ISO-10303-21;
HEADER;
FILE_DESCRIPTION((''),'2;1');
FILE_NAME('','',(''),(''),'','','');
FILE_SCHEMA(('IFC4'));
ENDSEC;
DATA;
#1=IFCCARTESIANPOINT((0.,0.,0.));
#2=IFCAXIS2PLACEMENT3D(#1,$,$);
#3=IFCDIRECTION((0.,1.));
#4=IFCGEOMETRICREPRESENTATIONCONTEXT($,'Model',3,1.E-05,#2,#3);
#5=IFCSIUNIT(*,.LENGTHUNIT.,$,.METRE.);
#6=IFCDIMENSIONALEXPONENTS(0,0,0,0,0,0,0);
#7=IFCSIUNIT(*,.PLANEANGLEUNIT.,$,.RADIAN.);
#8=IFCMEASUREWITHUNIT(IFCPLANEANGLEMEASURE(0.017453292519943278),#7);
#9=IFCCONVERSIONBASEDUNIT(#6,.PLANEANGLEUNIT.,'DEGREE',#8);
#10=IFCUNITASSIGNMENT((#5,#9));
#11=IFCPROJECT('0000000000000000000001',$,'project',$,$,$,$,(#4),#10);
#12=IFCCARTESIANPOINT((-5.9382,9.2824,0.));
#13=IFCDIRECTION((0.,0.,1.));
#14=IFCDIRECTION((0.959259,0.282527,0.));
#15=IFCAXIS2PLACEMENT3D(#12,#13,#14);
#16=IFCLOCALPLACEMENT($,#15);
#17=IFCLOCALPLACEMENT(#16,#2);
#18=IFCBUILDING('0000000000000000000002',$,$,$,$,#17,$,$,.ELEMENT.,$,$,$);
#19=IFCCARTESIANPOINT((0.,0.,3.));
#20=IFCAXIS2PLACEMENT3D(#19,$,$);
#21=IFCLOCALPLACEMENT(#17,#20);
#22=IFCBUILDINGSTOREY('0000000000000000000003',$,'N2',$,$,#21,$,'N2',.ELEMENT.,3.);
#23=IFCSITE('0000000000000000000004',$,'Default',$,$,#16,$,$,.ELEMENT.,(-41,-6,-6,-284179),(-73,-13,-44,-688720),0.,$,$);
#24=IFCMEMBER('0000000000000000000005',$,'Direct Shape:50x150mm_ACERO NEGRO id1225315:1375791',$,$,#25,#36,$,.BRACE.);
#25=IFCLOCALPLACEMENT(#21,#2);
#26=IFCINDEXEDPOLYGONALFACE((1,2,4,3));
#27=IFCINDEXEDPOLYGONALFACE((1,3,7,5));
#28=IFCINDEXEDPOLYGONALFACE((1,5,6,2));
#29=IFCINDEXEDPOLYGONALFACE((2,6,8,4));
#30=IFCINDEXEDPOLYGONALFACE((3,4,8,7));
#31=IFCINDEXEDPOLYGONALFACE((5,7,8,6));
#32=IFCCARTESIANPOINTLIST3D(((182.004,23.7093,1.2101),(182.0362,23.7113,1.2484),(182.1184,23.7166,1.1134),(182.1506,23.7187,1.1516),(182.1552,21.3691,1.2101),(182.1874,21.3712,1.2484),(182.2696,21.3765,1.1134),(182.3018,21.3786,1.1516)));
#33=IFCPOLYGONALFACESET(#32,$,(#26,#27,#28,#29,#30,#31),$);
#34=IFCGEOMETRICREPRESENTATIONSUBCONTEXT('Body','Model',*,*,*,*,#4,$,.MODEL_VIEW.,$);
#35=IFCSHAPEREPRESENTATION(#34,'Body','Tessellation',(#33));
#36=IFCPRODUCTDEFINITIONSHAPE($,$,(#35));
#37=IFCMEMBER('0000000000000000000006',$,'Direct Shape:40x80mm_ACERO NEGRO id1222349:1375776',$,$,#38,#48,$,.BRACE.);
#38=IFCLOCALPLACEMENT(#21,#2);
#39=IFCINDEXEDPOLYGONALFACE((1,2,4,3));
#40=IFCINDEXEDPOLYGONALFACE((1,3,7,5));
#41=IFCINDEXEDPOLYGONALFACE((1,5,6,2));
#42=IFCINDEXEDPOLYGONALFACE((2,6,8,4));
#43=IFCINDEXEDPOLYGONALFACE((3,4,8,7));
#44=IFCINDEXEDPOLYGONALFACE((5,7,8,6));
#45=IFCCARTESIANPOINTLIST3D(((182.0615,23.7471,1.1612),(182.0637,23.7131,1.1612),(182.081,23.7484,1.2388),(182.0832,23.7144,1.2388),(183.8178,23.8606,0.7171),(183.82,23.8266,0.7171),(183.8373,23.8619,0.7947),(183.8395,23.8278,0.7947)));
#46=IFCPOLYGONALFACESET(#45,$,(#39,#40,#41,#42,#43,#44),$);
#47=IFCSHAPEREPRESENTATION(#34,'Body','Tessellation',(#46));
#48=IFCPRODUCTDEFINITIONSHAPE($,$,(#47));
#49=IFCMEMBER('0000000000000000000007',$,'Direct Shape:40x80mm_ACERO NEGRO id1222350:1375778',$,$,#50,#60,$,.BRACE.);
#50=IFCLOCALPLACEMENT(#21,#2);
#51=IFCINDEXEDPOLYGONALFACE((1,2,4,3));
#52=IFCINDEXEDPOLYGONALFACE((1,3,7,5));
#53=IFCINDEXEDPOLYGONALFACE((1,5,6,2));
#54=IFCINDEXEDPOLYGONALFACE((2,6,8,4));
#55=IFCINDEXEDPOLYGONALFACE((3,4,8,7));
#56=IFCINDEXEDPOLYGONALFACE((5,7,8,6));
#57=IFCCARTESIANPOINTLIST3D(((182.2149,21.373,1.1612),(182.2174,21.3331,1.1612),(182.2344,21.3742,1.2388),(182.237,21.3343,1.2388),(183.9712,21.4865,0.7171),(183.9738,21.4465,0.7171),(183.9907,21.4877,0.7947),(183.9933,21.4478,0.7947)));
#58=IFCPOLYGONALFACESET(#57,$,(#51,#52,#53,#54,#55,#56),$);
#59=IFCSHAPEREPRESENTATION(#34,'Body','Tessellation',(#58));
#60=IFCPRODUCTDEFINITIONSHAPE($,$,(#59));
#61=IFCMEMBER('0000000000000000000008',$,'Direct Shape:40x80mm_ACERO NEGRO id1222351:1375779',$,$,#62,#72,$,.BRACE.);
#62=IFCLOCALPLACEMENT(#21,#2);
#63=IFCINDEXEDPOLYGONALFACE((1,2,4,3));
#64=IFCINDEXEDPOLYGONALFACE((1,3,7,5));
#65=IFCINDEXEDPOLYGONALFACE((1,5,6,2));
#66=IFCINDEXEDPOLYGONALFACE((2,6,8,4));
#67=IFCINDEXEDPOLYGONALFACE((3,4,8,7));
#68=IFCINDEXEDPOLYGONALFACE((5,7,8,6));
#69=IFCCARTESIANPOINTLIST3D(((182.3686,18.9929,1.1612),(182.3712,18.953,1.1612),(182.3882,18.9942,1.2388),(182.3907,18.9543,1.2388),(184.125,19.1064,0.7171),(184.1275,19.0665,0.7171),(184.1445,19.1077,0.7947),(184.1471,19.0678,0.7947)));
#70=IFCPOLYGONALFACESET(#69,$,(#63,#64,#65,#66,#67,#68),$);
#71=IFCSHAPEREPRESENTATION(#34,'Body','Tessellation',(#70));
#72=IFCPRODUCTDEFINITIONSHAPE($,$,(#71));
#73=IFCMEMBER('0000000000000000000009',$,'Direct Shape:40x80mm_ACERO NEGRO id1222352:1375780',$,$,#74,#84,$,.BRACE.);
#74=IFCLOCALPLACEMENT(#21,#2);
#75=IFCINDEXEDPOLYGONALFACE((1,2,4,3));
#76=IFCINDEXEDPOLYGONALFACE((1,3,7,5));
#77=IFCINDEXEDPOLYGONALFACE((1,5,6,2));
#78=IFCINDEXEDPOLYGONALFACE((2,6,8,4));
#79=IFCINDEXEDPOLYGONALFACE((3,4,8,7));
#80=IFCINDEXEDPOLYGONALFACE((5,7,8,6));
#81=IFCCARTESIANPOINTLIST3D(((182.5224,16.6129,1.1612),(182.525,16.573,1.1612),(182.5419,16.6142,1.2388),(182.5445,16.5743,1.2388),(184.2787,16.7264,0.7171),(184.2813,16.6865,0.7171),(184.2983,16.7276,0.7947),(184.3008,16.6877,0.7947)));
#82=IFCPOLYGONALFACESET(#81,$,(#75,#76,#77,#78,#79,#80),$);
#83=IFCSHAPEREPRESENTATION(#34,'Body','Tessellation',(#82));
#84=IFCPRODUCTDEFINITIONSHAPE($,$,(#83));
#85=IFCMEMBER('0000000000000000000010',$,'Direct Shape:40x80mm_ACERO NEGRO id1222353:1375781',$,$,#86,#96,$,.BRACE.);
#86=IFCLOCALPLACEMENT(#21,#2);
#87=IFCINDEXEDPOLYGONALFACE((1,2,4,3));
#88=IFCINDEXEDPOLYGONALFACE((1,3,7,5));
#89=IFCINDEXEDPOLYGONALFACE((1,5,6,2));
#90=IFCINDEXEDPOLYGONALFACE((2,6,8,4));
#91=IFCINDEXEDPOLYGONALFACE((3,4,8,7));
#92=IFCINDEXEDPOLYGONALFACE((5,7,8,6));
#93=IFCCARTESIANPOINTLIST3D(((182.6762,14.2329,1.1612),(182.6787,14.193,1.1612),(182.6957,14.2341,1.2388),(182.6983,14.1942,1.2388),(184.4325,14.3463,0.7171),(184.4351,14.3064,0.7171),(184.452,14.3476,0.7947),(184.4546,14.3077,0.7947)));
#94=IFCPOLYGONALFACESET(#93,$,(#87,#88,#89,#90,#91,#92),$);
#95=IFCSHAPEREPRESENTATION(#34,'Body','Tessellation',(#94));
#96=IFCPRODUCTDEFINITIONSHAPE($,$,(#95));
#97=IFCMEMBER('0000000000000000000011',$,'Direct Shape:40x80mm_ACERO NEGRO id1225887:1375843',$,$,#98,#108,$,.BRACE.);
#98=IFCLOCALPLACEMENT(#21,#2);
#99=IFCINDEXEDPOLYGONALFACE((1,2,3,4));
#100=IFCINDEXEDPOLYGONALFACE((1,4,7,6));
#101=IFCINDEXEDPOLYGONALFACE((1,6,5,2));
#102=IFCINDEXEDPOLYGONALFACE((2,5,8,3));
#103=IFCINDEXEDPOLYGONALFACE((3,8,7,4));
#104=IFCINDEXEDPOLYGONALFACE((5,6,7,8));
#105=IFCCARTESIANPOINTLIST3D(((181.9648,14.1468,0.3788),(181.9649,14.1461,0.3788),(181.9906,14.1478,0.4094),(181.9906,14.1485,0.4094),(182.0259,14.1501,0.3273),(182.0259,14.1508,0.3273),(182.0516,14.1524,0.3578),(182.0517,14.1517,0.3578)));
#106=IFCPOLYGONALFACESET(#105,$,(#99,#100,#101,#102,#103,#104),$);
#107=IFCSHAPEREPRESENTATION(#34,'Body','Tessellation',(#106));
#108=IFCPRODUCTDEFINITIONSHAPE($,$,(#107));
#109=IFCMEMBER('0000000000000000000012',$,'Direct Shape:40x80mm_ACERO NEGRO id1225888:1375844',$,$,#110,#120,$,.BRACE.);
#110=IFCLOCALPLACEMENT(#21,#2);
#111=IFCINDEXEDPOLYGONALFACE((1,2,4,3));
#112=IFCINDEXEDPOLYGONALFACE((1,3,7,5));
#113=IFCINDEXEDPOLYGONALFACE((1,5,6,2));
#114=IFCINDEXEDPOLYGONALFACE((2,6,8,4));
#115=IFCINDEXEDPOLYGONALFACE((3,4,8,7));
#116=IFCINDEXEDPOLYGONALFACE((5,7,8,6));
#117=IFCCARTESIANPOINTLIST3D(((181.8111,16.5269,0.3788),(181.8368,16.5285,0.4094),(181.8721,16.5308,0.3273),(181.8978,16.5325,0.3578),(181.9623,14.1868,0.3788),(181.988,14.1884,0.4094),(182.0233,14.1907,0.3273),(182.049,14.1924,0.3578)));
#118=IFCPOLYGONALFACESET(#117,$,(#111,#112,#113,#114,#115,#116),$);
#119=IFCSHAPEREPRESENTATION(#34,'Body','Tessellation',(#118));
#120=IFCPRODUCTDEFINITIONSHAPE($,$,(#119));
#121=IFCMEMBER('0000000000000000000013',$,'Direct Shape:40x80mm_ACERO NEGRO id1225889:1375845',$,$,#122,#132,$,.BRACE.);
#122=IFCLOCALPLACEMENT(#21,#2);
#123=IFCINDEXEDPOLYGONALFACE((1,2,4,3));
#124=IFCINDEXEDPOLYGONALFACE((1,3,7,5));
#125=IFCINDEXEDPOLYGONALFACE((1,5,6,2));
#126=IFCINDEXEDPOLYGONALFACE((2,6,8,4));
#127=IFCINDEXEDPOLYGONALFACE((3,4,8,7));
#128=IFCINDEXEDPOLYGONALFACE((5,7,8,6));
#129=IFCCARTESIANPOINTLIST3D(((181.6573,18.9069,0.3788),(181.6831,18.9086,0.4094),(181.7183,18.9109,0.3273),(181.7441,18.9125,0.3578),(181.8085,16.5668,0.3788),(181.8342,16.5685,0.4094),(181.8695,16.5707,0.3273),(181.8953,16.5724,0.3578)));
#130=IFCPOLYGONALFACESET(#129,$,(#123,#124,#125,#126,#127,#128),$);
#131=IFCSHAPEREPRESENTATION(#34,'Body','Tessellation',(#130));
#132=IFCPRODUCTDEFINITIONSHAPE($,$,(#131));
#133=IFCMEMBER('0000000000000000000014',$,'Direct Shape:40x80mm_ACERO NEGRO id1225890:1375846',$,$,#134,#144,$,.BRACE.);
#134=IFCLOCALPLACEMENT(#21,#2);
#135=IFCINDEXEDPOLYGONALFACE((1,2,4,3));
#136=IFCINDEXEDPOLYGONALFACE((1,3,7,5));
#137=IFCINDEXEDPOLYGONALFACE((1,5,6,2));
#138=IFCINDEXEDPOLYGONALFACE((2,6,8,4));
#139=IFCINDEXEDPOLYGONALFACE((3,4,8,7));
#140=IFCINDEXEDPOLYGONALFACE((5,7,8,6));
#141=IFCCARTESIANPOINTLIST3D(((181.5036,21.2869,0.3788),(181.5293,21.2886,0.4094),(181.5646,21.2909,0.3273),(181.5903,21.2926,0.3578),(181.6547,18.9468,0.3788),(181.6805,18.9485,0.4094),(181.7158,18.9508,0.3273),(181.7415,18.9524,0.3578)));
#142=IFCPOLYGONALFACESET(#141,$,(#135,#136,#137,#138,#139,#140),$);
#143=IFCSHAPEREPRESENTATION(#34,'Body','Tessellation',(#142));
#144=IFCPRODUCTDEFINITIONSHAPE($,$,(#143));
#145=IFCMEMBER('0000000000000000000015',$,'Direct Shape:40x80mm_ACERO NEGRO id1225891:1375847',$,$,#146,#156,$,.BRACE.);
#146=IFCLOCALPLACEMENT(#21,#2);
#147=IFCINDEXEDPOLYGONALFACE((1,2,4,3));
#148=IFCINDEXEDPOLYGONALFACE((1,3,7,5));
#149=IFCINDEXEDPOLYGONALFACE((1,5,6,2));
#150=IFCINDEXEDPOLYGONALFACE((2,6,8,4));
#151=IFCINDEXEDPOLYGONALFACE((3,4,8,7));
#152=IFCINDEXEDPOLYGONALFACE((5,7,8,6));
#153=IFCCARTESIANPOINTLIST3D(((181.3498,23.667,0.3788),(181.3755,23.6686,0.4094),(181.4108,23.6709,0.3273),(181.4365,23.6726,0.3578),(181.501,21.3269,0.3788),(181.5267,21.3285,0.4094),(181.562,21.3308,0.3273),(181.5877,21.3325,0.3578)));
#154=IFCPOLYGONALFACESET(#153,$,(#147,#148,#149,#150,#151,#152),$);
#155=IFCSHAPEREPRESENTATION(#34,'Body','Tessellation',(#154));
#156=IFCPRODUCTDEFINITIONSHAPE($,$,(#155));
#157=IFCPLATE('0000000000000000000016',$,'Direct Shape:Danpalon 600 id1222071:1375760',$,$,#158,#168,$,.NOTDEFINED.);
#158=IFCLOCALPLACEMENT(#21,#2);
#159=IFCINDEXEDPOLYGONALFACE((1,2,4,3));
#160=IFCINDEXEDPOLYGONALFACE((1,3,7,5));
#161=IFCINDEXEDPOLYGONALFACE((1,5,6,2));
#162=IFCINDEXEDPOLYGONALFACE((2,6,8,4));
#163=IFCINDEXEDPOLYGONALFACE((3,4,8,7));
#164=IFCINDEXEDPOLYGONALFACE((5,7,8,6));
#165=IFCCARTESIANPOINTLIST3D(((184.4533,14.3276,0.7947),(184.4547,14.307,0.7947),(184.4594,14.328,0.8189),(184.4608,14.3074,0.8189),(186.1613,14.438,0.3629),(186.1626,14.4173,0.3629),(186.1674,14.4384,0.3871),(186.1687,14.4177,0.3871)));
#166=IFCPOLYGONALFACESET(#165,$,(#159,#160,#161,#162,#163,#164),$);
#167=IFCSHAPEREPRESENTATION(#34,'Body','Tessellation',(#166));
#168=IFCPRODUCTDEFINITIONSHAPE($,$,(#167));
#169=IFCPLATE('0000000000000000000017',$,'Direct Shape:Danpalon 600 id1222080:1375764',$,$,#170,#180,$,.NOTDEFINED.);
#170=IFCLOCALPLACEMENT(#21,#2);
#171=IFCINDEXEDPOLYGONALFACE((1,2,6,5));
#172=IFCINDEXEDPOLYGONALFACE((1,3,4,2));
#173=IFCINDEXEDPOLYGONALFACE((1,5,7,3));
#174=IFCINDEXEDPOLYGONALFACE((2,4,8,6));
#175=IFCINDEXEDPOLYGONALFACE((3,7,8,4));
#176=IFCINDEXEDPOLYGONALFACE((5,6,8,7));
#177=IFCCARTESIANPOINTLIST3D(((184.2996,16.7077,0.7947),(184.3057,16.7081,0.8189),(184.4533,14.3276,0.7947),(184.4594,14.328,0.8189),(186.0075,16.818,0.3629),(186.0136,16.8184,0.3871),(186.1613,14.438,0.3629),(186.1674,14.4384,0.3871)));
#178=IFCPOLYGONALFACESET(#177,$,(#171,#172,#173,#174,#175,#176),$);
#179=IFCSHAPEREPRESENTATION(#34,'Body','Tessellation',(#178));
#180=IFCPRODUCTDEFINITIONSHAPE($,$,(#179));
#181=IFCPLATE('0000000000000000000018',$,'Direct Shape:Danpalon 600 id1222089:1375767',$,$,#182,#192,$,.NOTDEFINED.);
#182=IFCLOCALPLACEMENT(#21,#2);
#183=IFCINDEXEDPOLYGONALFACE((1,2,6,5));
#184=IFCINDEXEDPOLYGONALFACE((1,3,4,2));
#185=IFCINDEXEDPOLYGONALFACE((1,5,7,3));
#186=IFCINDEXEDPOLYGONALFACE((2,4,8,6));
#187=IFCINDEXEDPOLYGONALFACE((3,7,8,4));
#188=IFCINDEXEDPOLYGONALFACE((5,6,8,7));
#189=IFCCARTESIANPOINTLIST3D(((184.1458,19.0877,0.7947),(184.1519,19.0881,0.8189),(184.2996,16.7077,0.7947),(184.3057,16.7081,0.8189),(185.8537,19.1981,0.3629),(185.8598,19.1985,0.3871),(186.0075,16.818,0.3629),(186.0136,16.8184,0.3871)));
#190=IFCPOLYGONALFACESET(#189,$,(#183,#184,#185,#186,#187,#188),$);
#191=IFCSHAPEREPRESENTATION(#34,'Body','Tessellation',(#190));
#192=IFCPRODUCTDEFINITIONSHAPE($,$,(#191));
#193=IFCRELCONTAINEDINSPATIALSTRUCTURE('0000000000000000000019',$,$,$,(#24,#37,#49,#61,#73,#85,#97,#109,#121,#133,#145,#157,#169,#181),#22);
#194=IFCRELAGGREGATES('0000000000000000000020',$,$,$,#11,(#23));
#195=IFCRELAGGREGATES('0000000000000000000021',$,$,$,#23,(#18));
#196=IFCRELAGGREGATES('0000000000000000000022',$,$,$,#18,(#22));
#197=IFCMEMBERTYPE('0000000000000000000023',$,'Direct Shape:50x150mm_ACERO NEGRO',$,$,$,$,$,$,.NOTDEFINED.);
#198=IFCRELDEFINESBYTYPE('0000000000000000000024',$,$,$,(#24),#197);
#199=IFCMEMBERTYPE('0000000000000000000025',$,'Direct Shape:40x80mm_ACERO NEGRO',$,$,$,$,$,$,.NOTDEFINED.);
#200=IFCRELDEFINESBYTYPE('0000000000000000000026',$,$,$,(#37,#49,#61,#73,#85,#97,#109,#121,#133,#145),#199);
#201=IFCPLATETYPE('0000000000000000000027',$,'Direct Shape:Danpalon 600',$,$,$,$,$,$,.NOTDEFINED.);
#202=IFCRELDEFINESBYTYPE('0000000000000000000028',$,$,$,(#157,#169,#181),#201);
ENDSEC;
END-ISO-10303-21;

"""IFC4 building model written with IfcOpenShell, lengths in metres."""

from ifc_helpers import new_model, entity, si_unit, converted_unit, direction, frame, frame_2d, origin, place, context, subcontext, project, spatial, rectangle, extrude, type_object, element, save


model = new_model("IFC4")

# Units and contexts
model_context = context("Model", 3, precision=1e-05, world=origin(), true_north=direction((0.0, 1.0)))
body_context = subcontext(model_context, "Body", "Model", "MODEL_VIEW")
ifc_project = project(units=[si_unit("LENGTHUNIT", "METRE"), converted_unit("PLANEANGLEUNIT", "DEGREE", entity("IfcPlaneAngleMeasure", 0.017453292519943278), si_unit("PLANEANGLEUNIT", "RADIAN"), dimensions=[0, 0, 0, 0, 0, 0, 0])], contexts=[model_context])

# Site, building, storey
site_placement = place(None, frame((-5.9382, 9.2824, 0.0), z_axis=(0.0, 0.0, 1.0), x_axis=(0.959259, 0.282527, 0.0)))
site = spatial("IfcSite", under=ifc_project, at=site_placement, Name="Default", CompositionType="ELEMENT", RefLatitude=(-41, -6, -6, -284179), RefLongitude=(-73, -13, -44, -688720), RefElevation=0.0)
building_placement = place(site_placement, origin())
building = spatial("IfcBuilding", under=site, at=building_placement, CompositionType="ELEMENT")
storey_placement = place(building_placement, frame((0.0, 0.0, 3.0)))
storey = spatial("IfcBuildingStorey", under=building, at=storey_placement, Name="N2", LongName="N2", CompositionType="ELEMENT", Elevation=3.0)

# Members
member_type_1 = type_object("IfcMemberType", Name="Direct Shape:50x150mm_ACERO NEGRO", PredefinedType="NOTDEFINED")
member_1_placement = place(storey_placement, origin())
element("IfcMember", 1, at=member_1_placement, inside=storey, type_object=member_type_1, Name="Direct Shape:50x150mm_ACERO NEGRO id1225315:1375791", PredefinedType="BRACE", context=body_context, shape_type="SweptSolid", body=[
    extrude(rectangle(XDim=0.05, YDim=0.15, at=frame_2d((0.0, 0.0), x_axis=(0.0, 1.0))), frame((182.2285, 21.3739, 1.1809), z_axis=(-0.064471, 0.99792, 0.0), x_axis=(0.762714, 0.049276, -0.644857)), (0.0, 0.0, 1.0), 2.345),
])
member_type_2 = type_object("IfcMemberType", Name="Direct Shape:40x80mm_ACERO NEGRO", PredefinedType="NOTDEFINED")
member_2_placement = place(storey_placement, origin())
element("IfcMember", 2, at=member_2_placement, inside=storey, type_object=member_type_2, Name="Direct Shape:40x80mm_ACERO NEGRO id1222349:1375776", PredefinedType="BRACE", context=body_context, shape_type="SweptSolid", body=[
    extrude(rectangle(XDim=0.08, YDim=0.0341, at=frame_2d((0.0, 0.0), x_axis=(0.0, 1.0))), frame((182.0723, 23.7308, 1.2), z_axis=(0.967595, 0.062512, -0.244649), x_axis=(0.064471, -0.99792, 0.0)), (0.0, 0.0, 1.0), 1.8152),
])
member_3_placement = place(storey_placement, origin())
element("IfcMember", 3, at=member_3_placement, inside=storey, type_object=member_type_2, Name="Direct Shape:40x80mm_ACERO NEGRO id1222350:1375778", PredefinedType="BRACE", context=body_context, shape_type="SweptSolid", body=[
    extrude(rectangle(XDim=0.08, YDim=0.04, at=frame_2d((0.0, 0.0), x_axis=(1.0, 0.0))), frame((182.2259, 21.3537, 1.2), z_axis=(0.967595, 0.062512, -0.244649), x_axis=(-0.24414, -0.015773, -0.969612)), (0.0, 0.0, 1.0), 1.8152),
])
member_4_placement = place(storey_placement, origin())
element("IfcMember", 4, at=member_4_placement, inside=storey, type_object=member_type_2, Name="Direct Shape:40x80mm_ACERO NEGRO id1222351:1375779", PredefinedType="BRACE", context=body_context, shape_type="SweptSolid", body=[
    extrude(rectangle(XDim=0.08, YDim=0.04, at=frame_2d((0.0, 0.0), x_axis=(1.0, 0.0))), frame((182.3797, 18.9736, 1.2), z_axis=(0.967595, 0.062512, -0.244649), x_axis=(-0.24414, -0.015773, -0.969612)), (0.0, 0.0, 1.0), 1.8152),
])
member_5_placement = place(storey_placement, origin())
element("IfcMember", 5, at=member_5_placement, inside=storey, type_object=member_type_2, Name="Direct Shape:40x80mm_ACERO NEGRO id1222352:1375780", PredefinedType="BRACE", context=body_context, shape_type="SweptSolid", body=[
    extrude(rectangle(XDim=0.08, YDim=0.04, at=frame_2d((0.0, 0.0), x_axis=(1.0, 0.0))), frame((182.5334, 16.5936, 1.2), z_axis=(0.967595, 0.062512, -0.244649), x_axis=(-0.24414, -0.015773, -0.969612)), (0.0, 0.0, 1.0), 1.8152),
])
member_6_placement = place(storey_placement, origin())
element("IfcMember", 6, at=member_6_placement, inside=storey, type_object=member_type_2, Name="Direct Shape:40x80mm_ACERO NEGRO id1222353:1375781", PredefinedType="BRACE", context=body_context, shape_type="SweptSolid", body=[
    extrude(rectangle(XDim=0.08, YDim=0.04, at=frame_2d((0.0, 0.0), x_axis=(1.0, 0.0))), frame((182.6872, 14.2135, 1.2), z_axis=(0.967595, 0.062512, -0.244649), x_axis=(-0.24414, -0.015773, -0.969612)), (0.0, 0.0, 1.0), 1.8152),
])
member_7_placement = place(storey_placement, origin())
element("IfcMember", 7, at=member_7_placement, inside=storey, type_object=member_type_2, Name="Direct Shape:40x80mm_ACERO NEGRO id1225887:1375843", PredefinedType="BRACE", context=body_context, shape_type="SweptSolid", body=[
    extrude(rectangle(XDim=0.04, YDim=0.0007, at=frame_2d((0.0, 0.0), x_axis=(0.0, 1.0))), frame((181.9777, 14.1473, 0.3941), z_axis=(0.762714, 0.049276, -0.644857), x_axis=(-0.064471, 0.99792, 0.0)), (0.0, 0.0, 1.0), 0.08),
])
member_8_placement = place(storey_placement, origin())
element("IfcMember", 8, at=member_8_placement, inside=storey, type_object=member_type_2, Name="Direct Shape:40x80mm_ACERO NEGRO id1225888:1375844", PredefinedType="BRACE", context=body_context, shape_type="SweptSolid", body=[
    extrude(rectangle(XDim=0.04, YDim=0.08, at=frame_2d((0.0, 0.0), x_axis=(0.0, 1.0))), frame((182.0056, 14.1896, 0.3683), z_axis=(-0.064471, 0.99792, 0.0), x_axis=(0.762714, 0.049276, -0.644857)), (0.0, 0.0, 1.0), 2.345),
])
member_9_placement = place(storey_placement, origin())
element("IfcMember", 9, at=member_9_placement, inside=storey, type_object=member_type_2, Name="Direct Shape:40x80mm_ACERO NEGRO id1225889:1375845", PredefinedType="BRACE", context=body_context, shape_type="SweptSolid", body=[
    extrude(rectangle(XDim=0.04, YDim=0.08, at=frame_2d((0.0, 0.0), x_axis=(0.0, 1.0))), frame((181.8519, 16.5696, 0.3683), z_axis=(-0.064471, 0.99792, 0.0), x_axis=(0.762714, 0.049276, -0.644857)), (0.0, 0.0, 1.0), 2.345),
])
member_10_placement = place(storey_placement, origin())
element("IfcMember", 10, at=member_10_placement, inside=storey, type_object=member_type_2, Name="Direct Shape:40x80mm_ACERO NEGRO id1225890:1375846", PredefinedType="BRACE", context=body_context, shape_type="SweptSolid", body=[
    extrude(rectangle(XDim=0.04, YDim=0.08, at=frame_2d((0.0, 0.0), x_axis=(0.0, 1.0))), frame((181.6981, 18.9496, 0.3683), z_axis=(-0.064471, 0.99792, 0.0), x_axis=(0.762714, 0.049276, -0.644857)), (0.0, 0.0, 1.0), 2.345),
])
member_11_placement = place(storey_placement, origin())
element("IfcMember", 11, at=member_11_placement, inside=storey, type_object=member_type_2, Name="Direct Shape:40x80mm_ACERO NEGRO id1225891:1375847", PredefinedType="BRACE", context=body_context, shape_type="SweptSolid", body=[
    extrude(rectangle(XDim=0.04, YDim=0.08, at=frame_2d((0.0, 0.0), x_axis=(0.0, 1.0))), frame((181.5444, 21.3297, 0.3683), z_axis=(-0.064471, 0.99792, 0.0), x_axis=(0.762714, 0.049276, -0.644857)), (0.0, 0.0, 1.0), 2.345),
])

# Plates
plate_type = type_object("IfcPlateType", Name="Direct Shape:Danpalon 600", PredefinedType="NOTDEFINED")
plate_1_placement = place(storey_placement, origin())
element("IfcPlate", 12, at=plate_1_placement, inside=storey, type_object=plate_type, Name="Direct Shape:Danpalon 600 id1222071:1375760", PredefinedType="NOTDEFINED", context=body_context, shape_type="SweptSolid", body=[
    extrude(rectangle(XDim=0.025, YDim=0.0207, at=frame_2d((0.0, 0.0), x_axis=(0.0, 1.0))), frame((184.457, 14.3175, 0.8068), z_axis=(0.967595, 0.062512, -0.244649), x_axis=(-0.064471, 0.99792, 0.0)), (0.0, 0.0, 1.0), 1.7652),
])
plate_2_placement = place(storey_placement, origin())
element("IfcPlate", 13, at=plate_2_placement, inside=storey, type_object=plate_type, Name="Direct Shape:Danpalon 600 id1222080:1375764", PredefinedType="NOTDEFINED", context=body_context, shape_type="SweptSolid", body=[
    extrude(rectangle(XDim=0.025, YDim=1.7652, at=frame_2d((0.0, 0.0), x_axis=(1.0, 0.0))), frame((185.3103, 14.383, 0.5909), z_axis=(-0.064471, 0.99792, 0.0), x_axis=(0.24414, 0.015773, 0.969612)), (0.0, 0.0, 1.0), 2.385),
])
plate_3_placement = place(storey_placement, origin())
element("IfcPlate", 14, at=plate_3_placement, inside=storey, type_object=plate_type, Name="Direct Shape:Danpalon 600 id1222089:1375767", PredefinedType="NOTDEFINED", context=body_context, shape_type="SweptSolid", body=[
    extrude(rectangle(XDim=0.025, YDim=1.7652, at=frame_2d((0.0, 0.0), x_axis=(1.0, 0.0))), frame((185.1566, 16.7631, 0.5909), z_axis=(-0.064471, 0.99792, 0.0), x_axis=(0.24414, 0.015773, 0.969612)), (0.0, 0.0, 1.0), 2.385),
])

save(model, "model.ifc")
